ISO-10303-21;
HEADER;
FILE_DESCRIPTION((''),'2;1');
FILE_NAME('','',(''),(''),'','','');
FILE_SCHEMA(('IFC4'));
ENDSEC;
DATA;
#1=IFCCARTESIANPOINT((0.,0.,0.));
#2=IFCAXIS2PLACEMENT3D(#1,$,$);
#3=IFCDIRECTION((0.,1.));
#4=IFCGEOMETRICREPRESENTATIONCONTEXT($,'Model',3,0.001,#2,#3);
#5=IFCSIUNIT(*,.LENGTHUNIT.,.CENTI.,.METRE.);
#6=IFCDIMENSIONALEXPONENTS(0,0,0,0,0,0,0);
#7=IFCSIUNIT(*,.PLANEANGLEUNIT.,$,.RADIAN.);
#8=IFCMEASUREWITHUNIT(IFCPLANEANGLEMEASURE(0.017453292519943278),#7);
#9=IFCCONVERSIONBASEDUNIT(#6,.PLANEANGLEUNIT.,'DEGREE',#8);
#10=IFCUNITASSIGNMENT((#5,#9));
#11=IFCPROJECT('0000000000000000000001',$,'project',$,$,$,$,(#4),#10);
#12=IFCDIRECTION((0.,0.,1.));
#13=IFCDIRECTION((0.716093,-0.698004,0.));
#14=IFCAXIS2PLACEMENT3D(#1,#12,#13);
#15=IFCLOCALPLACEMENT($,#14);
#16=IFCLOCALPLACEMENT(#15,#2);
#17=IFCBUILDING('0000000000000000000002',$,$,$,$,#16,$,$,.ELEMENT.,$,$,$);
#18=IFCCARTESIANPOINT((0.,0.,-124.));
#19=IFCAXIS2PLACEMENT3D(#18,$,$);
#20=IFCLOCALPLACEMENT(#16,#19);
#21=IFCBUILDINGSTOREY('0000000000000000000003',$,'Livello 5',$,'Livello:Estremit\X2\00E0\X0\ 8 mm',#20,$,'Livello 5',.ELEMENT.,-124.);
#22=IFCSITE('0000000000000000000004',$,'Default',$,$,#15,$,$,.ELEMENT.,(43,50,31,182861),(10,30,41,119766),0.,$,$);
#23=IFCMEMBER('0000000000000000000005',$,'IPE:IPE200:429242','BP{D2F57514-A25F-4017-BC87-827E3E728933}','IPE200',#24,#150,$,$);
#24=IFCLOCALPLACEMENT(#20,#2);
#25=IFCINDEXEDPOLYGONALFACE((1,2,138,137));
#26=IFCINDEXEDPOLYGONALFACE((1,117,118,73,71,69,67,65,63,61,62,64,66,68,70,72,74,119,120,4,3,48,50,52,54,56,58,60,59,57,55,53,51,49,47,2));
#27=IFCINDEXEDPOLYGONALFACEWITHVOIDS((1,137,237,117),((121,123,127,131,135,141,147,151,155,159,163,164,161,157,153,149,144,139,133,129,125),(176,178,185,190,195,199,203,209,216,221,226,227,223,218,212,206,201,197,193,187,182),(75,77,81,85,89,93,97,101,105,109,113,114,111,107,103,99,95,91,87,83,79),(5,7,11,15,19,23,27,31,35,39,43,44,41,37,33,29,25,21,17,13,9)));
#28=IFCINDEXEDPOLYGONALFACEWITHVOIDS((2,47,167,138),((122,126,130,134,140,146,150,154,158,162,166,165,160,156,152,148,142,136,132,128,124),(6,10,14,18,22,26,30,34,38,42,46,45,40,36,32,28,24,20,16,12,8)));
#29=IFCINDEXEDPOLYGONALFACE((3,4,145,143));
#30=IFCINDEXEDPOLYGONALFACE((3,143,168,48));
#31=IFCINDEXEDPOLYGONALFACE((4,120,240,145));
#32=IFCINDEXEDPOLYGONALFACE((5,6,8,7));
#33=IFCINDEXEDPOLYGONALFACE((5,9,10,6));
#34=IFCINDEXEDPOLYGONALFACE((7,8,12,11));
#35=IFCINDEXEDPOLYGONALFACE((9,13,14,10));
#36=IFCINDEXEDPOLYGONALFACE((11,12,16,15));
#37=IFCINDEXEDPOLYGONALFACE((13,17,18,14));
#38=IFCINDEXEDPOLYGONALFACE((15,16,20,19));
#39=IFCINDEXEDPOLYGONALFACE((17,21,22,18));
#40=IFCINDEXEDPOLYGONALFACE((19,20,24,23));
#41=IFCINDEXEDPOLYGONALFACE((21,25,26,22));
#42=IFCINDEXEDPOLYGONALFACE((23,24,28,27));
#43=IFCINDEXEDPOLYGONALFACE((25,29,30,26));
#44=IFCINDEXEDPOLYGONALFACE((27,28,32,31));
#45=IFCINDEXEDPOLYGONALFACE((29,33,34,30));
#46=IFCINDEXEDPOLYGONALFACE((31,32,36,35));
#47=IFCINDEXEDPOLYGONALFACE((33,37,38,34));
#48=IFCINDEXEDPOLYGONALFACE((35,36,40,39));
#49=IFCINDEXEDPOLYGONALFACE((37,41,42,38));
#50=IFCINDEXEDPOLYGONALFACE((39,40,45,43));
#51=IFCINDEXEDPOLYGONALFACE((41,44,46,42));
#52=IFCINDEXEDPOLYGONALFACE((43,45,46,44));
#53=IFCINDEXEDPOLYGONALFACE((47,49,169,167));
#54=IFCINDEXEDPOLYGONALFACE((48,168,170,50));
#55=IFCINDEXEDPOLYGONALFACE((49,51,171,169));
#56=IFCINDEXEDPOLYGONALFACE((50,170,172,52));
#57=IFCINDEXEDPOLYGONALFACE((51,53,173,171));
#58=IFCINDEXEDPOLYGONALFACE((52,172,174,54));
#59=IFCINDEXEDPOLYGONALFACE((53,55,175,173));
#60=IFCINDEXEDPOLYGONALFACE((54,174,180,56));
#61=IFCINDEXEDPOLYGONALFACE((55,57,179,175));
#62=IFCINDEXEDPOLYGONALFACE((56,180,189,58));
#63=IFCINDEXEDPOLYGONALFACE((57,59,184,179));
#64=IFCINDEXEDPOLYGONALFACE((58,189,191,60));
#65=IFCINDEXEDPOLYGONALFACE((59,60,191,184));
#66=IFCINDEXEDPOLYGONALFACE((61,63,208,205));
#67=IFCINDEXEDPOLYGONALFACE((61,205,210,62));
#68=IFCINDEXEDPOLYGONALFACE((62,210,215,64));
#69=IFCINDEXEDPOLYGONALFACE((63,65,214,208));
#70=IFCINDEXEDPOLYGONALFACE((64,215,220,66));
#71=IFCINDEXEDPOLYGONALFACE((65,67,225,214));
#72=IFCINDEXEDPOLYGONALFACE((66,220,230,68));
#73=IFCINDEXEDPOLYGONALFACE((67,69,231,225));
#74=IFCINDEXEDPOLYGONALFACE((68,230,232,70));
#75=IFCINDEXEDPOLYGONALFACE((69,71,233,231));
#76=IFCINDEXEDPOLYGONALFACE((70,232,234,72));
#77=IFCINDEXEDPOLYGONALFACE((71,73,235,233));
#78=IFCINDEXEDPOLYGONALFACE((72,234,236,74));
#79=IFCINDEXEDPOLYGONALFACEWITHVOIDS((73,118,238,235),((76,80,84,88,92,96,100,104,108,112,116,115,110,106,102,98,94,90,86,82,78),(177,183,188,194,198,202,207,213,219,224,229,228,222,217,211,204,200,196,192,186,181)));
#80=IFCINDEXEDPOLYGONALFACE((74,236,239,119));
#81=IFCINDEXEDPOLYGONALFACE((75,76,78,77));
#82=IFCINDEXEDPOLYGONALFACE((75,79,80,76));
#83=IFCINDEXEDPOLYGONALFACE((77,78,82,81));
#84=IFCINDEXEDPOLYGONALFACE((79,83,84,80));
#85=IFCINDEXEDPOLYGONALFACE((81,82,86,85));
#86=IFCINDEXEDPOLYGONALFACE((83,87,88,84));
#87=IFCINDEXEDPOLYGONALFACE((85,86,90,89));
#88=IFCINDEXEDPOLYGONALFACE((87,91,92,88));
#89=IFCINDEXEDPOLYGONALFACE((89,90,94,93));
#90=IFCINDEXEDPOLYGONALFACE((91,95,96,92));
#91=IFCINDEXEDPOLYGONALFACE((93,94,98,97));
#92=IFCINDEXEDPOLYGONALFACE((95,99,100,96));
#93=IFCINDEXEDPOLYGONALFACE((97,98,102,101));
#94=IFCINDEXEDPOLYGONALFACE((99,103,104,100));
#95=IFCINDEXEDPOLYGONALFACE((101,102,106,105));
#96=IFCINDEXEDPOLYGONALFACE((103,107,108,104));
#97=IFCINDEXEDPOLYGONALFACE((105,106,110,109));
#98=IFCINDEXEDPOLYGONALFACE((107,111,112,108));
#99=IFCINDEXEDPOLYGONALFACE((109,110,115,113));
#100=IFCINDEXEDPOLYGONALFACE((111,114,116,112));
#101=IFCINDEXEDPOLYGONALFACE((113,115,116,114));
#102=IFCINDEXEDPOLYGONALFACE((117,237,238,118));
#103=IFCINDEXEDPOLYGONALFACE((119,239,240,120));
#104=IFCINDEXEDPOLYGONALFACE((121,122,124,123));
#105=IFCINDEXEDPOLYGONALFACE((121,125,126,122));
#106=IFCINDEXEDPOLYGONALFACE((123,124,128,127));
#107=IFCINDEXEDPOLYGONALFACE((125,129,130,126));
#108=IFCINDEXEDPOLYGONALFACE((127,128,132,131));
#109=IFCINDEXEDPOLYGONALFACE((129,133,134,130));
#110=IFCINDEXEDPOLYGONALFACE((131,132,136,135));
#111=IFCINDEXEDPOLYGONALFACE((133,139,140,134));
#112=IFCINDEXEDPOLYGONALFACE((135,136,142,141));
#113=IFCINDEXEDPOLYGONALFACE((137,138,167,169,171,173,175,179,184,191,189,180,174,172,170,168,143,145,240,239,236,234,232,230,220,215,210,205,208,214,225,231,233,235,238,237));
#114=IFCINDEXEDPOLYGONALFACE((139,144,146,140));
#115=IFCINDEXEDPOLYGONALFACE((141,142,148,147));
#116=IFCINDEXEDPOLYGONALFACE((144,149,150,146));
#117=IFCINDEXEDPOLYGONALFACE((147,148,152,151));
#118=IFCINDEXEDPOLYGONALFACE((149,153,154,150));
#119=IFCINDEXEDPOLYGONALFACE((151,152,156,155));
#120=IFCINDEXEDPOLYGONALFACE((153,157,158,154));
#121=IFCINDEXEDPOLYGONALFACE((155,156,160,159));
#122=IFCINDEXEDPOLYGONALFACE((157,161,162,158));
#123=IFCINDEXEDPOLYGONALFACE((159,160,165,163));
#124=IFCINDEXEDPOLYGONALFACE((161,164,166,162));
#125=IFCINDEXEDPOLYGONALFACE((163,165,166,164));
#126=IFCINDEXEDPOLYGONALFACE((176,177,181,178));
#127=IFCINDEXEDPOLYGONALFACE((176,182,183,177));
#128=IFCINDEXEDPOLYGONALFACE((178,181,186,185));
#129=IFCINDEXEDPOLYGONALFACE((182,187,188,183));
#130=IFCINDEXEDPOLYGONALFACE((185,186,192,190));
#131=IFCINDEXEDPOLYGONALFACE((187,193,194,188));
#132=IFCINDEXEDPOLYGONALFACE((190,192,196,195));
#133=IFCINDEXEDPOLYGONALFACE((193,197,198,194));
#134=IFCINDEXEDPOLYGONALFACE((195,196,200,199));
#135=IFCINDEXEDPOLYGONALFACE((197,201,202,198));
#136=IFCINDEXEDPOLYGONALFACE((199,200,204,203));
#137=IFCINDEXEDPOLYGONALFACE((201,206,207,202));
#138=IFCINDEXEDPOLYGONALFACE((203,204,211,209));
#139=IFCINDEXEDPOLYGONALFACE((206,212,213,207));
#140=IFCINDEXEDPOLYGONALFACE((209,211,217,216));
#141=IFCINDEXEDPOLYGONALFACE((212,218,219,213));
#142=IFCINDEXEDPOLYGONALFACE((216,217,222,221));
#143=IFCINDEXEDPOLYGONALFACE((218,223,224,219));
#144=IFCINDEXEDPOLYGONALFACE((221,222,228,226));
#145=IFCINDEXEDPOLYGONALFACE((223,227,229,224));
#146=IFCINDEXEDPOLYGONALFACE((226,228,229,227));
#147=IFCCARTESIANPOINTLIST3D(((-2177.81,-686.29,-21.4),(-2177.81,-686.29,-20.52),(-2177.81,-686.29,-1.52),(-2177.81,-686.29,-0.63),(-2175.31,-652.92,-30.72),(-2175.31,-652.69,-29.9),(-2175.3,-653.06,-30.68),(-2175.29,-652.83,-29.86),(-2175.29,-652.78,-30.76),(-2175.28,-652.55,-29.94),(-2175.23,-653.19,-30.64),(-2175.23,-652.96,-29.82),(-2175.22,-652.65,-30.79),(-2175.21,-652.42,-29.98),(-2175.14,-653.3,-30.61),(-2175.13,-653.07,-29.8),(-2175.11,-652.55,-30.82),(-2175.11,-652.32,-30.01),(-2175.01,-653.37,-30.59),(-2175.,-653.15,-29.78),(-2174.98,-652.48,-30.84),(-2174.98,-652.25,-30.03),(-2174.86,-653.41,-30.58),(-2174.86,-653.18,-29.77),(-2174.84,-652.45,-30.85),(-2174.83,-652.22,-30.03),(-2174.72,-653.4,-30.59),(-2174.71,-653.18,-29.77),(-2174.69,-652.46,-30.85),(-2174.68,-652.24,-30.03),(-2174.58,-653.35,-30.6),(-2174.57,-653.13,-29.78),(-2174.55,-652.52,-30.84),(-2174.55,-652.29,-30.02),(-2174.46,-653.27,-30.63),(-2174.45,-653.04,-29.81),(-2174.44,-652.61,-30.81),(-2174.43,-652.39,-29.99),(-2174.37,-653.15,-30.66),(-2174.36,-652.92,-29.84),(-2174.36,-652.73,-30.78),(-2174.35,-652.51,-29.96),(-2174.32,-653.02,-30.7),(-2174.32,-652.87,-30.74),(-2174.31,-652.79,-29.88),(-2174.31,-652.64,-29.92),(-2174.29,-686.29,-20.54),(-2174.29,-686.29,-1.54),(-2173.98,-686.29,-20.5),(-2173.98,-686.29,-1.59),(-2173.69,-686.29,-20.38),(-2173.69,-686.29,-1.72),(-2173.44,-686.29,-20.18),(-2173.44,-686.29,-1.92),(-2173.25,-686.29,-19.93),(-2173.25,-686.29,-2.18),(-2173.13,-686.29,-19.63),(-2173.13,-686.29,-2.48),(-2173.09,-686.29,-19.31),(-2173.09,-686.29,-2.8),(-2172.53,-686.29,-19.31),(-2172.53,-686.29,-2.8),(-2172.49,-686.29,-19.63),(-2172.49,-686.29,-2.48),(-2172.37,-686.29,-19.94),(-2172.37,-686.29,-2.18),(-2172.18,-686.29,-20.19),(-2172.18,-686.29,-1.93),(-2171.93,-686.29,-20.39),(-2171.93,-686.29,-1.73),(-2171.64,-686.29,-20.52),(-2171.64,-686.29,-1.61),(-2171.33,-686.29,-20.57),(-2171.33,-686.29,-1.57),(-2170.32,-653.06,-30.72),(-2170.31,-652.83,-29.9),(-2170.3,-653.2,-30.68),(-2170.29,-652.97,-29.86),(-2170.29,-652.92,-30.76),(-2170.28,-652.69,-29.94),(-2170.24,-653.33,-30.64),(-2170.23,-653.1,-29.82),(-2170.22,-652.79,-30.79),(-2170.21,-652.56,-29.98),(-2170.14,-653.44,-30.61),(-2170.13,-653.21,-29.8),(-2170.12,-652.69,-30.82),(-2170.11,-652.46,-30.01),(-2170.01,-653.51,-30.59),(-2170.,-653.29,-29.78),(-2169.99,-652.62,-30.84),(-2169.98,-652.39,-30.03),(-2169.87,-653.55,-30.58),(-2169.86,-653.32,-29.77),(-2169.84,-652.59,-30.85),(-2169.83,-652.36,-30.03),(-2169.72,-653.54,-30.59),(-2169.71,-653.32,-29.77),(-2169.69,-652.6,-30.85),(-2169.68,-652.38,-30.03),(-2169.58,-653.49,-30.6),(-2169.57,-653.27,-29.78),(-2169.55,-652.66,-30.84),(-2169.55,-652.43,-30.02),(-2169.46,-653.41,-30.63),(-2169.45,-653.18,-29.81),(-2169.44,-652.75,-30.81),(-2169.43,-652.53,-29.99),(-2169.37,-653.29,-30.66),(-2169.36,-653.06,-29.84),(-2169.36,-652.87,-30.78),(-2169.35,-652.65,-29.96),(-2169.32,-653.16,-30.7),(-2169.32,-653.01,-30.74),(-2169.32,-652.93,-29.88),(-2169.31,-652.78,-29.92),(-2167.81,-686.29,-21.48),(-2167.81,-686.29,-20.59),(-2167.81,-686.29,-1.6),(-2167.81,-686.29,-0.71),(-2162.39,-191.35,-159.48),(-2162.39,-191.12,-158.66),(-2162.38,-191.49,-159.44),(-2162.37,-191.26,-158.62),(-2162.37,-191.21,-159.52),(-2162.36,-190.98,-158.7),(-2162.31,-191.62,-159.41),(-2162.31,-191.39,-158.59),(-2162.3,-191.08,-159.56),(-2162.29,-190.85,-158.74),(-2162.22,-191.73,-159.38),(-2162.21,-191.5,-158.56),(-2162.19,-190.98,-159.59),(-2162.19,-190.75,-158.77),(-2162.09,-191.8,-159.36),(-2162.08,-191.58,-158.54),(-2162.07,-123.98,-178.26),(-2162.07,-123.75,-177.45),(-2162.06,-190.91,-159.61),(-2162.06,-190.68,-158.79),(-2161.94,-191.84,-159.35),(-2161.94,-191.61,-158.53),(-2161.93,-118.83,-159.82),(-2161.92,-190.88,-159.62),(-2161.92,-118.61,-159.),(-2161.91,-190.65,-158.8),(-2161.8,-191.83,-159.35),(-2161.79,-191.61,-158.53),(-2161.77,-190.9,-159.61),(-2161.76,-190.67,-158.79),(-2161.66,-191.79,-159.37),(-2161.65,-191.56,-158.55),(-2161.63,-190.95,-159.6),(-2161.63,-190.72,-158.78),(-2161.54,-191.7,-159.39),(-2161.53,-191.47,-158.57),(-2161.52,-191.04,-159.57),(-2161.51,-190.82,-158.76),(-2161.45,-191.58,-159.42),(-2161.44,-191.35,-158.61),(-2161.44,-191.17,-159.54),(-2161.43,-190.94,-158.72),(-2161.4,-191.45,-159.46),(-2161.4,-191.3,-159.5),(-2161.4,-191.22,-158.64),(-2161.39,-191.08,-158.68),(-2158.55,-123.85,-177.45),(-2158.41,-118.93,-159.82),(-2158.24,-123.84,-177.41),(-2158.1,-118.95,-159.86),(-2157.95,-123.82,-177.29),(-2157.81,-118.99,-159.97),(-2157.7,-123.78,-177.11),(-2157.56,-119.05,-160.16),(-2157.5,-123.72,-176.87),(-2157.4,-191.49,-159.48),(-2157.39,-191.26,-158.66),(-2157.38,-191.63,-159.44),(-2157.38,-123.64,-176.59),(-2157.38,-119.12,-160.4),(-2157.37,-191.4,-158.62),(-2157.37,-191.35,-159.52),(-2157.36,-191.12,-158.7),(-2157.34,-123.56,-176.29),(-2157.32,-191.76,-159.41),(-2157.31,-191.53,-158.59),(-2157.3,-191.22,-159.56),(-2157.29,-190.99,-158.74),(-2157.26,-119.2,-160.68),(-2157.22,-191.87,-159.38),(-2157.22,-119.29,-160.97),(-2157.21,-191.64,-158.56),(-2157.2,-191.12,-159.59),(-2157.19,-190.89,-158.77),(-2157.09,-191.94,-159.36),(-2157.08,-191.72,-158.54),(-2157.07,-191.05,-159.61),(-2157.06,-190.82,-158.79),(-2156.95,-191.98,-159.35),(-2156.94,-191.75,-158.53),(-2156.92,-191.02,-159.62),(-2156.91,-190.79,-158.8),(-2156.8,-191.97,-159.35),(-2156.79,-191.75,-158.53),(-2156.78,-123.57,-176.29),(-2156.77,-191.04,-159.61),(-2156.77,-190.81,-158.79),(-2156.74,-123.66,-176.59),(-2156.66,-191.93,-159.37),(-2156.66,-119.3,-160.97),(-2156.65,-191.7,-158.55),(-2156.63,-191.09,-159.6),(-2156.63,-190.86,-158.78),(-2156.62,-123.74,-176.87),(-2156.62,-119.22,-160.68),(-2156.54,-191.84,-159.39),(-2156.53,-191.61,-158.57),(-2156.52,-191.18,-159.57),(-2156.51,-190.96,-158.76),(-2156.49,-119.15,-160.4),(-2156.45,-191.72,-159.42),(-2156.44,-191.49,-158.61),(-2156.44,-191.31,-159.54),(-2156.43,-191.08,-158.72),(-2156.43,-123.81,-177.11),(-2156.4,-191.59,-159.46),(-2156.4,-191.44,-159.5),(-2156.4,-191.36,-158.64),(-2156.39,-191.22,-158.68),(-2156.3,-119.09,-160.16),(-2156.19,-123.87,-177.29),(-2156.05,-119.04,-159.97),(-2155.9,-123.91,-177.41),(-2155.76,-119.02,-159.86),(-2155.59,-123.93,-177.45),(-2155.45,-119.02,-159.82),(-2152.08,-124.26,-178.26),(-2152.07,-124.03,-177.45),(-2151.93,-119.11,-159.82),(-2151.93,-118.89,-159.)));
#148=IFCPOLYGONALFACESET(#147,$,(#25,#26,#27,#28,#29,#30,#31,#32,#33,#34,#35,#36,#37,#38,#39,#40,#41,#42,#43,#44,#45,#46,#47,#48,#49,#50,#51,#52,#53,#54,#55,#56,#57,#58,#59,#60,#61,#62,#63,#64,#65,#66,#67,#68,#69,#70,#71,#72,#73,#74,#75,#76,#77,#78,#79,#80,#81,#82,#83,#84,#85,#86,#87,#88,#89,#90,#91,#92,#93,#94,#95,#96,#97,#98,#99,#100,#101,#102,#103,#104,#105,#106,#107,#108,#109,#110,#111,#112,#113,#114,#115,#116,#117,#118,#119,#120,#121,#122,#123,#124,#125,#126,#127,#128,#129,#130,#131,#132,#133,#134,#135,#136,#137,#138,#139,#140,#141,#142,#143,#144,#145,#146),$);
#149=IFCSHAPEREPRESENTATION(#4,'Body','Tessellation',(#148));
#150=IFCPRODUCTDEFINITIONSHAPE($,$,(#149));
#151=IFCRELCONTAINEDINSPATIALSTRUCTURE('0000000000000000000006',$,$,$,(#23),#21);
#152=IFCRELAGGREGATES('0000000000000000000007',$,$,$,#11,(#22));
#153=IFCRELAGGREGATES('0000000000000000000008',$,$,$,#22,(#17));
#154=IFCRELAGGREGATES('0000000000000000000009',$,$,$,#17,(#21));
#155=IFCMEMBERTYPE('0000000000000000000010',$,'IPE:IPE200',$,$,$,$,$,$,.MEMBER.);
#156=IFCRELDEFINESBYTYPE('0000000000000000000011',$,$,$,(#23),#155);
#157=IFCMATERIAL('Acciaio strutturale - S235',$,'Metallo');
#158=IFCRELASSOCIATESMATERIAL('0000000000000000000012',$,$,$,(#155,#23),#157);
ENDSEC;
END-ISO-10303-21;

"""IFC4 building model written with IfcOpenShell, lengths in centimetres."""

from ifc_helpers import new_model, entity, si_unit, converted_unit, direction, frame, frame_2d, origin, origin_2d, place, context, project, spatial, circle, i_section, extrude, clip, halfspace, material, type_object, element, save


model = new_model("IFC4")

# Units and contexts
model_context = context("Model", 3, precision=0.001, world=origin(), true_north=direction((0.0, 1.0)))
ifc_project = project(units=[si_unit("LENGTHUNIT", "METRE", prefix="CENTI"), converted_unit("PLANEANGLEUNIT", "DEGREE", entity("IfcPlaneAngleMeasure", 0.017453292519943278), si_unit("PLANEANGLEUNIT", "RADIAN"), dimensions=[0, 0, 0, 0, 0, 0, 0])], contexts=[model_context])

# Site, building, storey
site_placement = place(None, frame((0.0, 0.0, 0.0), z_axis=(0.0, 0.0, 1.0), x_axis=(0.716093, -0.698004, 0.0)))
site = spatial("IfcSite", under=ifc_project, at=site_placement, Name="Default", CompositionType="ELEMENT", RefLatitude=(43, 50, 31, 182861), RefLongitude=(10, 30, 41, 119766), RefElevation=0.0)
building_placement = place(site_placement, origin())
building = spatial("IfcBuilding", under=site, at=building_placement, CompositionType="ELEMENT")
storey_placement = place(building_placement, frame((0.0, 0.0, -124.0)))
storey = spatial("IfcBuildingStorey", under=building, at=storey_placement, Name="Livello 5", ObjectType="Livello:Estremità 8 mm", LongName="Livello 5", CompositionType="ELEMENT", Elevation=-124.0)

# Shared definitions
ifc_material_1 = material(Name="Acciaio strutturale - S235", Category="Metallo")

# Member, openings
member_type_1 = type_object("IfcMemberType", Name="IPE:IPE200", PredefinedType="MEMBER", material=ifc_material_1)
member_1_placement = place(storey_placement, frame((-2173.93, -726.15, 0.07), z_axis=(-0.026952, -0.962871, 0.268612), x_axis=(0.999608, -0.02798, 0.0)))
member_1 = element("IfcMember", 1, at=member_1_placement, inside=storey, type_object=member_type_1, material=ifc_material_1, Name="IPE:IPE200:429242", Description="BP{D2F57514-A25F-4017-BC87-827E3E728933}", ObjectType="IPE200", context=model_context, shape_type="Clipping", body=[
    clip(extrude(i_section(OverallWidth=10.0, OverallDepth=20.0, WebThickness=0.56, FlangeThickness=0.85, FilletRadius=1.2, at=origin_2d()), origin(), (0.0, 0.0, -1.0), 628.04), halfspace(frame((2171.96, 146.42, -63.69), z_axis=(-0.02798, 0.268507, -0.962871), x_axis=(-0.999608, -0.007516, 0.026952)), True)),
])
opening_1_placement = place(member_1_placement, frame((1.56, -9.1, -78.75), z_axis=(0.0, 1.0, 0.0), x_axis=(-1.0, 0.0, 0.0)))
element("IfcOpeningElement", 2, at=opening_1_placement, cuts=member_1, ObjectType="Opening", context=model_context, shape_type="SweptSolid", body=[
    extrude(circle(Radius=0.5, at=frame_2d((-0.5, 0.0), x_axis=(1.0, 0.0))), origin(), (0.0, 0.0, -1.0), 0.95),
])
opening_2_placement = place(member_1_placement, frame((-3.44, -9.1, -78.75), z_axis=(0.0, 1.0, 0.0), x_axis=(-1.0, 0.0, 0.0)))
element("IfcOpeningElement", 3, at=opening_2_placement, cuts=member_1, ObjectType="Opening", context=model_context, shape_type="SweptSolid", body=[
    extrude(circle(Radius=0.5, at=frame_2d((-0.5, 0.0), x_axis=(1.0, 0.0))), origin(), (0.0, 0.0, -1.0), 0.95),
])
opening_3_placement = place(member_1_placement, frame((1.56, -9.1, -558.11), z_axis=(0.0, 1.0, 0.0), x_axis=(-1.0, 0.0, 0.0)))
element("IfcOpeningElement", 4, at=opening_3_placement, cuts=member_1, ObjectType="Opening", context=model_context, shape_type="SweptSolid", body=[
    extrude(circle(Radius=0.5, at=frame_2d((-0.5, 0.0), x_axis=(1.0, 0.0))), origin(), (0.0, 0.0, -1.0), 0.95),
])
opening_4_placement = place(member_1_placement, frame((-3.44, -9.1, -558.11), z_axis=(0.0, 1.0, 0.0), x_axis=(-1.0, 0.0, 0.0)))
element("IfcOpeningElement", 5, at=opening_4_placement, cuts=member_1, ObjectType="Opening", context=model_context, shape_type="SweptSolid", body=[
    extrude(circle(Radius=0.5, at=frame_2d((-0.5, 0.0), x_axis=(1.0, 0.0))), origin(), (0.0, 0.0, -1.0), 0.95),
])

save(model, "model.ifc")
